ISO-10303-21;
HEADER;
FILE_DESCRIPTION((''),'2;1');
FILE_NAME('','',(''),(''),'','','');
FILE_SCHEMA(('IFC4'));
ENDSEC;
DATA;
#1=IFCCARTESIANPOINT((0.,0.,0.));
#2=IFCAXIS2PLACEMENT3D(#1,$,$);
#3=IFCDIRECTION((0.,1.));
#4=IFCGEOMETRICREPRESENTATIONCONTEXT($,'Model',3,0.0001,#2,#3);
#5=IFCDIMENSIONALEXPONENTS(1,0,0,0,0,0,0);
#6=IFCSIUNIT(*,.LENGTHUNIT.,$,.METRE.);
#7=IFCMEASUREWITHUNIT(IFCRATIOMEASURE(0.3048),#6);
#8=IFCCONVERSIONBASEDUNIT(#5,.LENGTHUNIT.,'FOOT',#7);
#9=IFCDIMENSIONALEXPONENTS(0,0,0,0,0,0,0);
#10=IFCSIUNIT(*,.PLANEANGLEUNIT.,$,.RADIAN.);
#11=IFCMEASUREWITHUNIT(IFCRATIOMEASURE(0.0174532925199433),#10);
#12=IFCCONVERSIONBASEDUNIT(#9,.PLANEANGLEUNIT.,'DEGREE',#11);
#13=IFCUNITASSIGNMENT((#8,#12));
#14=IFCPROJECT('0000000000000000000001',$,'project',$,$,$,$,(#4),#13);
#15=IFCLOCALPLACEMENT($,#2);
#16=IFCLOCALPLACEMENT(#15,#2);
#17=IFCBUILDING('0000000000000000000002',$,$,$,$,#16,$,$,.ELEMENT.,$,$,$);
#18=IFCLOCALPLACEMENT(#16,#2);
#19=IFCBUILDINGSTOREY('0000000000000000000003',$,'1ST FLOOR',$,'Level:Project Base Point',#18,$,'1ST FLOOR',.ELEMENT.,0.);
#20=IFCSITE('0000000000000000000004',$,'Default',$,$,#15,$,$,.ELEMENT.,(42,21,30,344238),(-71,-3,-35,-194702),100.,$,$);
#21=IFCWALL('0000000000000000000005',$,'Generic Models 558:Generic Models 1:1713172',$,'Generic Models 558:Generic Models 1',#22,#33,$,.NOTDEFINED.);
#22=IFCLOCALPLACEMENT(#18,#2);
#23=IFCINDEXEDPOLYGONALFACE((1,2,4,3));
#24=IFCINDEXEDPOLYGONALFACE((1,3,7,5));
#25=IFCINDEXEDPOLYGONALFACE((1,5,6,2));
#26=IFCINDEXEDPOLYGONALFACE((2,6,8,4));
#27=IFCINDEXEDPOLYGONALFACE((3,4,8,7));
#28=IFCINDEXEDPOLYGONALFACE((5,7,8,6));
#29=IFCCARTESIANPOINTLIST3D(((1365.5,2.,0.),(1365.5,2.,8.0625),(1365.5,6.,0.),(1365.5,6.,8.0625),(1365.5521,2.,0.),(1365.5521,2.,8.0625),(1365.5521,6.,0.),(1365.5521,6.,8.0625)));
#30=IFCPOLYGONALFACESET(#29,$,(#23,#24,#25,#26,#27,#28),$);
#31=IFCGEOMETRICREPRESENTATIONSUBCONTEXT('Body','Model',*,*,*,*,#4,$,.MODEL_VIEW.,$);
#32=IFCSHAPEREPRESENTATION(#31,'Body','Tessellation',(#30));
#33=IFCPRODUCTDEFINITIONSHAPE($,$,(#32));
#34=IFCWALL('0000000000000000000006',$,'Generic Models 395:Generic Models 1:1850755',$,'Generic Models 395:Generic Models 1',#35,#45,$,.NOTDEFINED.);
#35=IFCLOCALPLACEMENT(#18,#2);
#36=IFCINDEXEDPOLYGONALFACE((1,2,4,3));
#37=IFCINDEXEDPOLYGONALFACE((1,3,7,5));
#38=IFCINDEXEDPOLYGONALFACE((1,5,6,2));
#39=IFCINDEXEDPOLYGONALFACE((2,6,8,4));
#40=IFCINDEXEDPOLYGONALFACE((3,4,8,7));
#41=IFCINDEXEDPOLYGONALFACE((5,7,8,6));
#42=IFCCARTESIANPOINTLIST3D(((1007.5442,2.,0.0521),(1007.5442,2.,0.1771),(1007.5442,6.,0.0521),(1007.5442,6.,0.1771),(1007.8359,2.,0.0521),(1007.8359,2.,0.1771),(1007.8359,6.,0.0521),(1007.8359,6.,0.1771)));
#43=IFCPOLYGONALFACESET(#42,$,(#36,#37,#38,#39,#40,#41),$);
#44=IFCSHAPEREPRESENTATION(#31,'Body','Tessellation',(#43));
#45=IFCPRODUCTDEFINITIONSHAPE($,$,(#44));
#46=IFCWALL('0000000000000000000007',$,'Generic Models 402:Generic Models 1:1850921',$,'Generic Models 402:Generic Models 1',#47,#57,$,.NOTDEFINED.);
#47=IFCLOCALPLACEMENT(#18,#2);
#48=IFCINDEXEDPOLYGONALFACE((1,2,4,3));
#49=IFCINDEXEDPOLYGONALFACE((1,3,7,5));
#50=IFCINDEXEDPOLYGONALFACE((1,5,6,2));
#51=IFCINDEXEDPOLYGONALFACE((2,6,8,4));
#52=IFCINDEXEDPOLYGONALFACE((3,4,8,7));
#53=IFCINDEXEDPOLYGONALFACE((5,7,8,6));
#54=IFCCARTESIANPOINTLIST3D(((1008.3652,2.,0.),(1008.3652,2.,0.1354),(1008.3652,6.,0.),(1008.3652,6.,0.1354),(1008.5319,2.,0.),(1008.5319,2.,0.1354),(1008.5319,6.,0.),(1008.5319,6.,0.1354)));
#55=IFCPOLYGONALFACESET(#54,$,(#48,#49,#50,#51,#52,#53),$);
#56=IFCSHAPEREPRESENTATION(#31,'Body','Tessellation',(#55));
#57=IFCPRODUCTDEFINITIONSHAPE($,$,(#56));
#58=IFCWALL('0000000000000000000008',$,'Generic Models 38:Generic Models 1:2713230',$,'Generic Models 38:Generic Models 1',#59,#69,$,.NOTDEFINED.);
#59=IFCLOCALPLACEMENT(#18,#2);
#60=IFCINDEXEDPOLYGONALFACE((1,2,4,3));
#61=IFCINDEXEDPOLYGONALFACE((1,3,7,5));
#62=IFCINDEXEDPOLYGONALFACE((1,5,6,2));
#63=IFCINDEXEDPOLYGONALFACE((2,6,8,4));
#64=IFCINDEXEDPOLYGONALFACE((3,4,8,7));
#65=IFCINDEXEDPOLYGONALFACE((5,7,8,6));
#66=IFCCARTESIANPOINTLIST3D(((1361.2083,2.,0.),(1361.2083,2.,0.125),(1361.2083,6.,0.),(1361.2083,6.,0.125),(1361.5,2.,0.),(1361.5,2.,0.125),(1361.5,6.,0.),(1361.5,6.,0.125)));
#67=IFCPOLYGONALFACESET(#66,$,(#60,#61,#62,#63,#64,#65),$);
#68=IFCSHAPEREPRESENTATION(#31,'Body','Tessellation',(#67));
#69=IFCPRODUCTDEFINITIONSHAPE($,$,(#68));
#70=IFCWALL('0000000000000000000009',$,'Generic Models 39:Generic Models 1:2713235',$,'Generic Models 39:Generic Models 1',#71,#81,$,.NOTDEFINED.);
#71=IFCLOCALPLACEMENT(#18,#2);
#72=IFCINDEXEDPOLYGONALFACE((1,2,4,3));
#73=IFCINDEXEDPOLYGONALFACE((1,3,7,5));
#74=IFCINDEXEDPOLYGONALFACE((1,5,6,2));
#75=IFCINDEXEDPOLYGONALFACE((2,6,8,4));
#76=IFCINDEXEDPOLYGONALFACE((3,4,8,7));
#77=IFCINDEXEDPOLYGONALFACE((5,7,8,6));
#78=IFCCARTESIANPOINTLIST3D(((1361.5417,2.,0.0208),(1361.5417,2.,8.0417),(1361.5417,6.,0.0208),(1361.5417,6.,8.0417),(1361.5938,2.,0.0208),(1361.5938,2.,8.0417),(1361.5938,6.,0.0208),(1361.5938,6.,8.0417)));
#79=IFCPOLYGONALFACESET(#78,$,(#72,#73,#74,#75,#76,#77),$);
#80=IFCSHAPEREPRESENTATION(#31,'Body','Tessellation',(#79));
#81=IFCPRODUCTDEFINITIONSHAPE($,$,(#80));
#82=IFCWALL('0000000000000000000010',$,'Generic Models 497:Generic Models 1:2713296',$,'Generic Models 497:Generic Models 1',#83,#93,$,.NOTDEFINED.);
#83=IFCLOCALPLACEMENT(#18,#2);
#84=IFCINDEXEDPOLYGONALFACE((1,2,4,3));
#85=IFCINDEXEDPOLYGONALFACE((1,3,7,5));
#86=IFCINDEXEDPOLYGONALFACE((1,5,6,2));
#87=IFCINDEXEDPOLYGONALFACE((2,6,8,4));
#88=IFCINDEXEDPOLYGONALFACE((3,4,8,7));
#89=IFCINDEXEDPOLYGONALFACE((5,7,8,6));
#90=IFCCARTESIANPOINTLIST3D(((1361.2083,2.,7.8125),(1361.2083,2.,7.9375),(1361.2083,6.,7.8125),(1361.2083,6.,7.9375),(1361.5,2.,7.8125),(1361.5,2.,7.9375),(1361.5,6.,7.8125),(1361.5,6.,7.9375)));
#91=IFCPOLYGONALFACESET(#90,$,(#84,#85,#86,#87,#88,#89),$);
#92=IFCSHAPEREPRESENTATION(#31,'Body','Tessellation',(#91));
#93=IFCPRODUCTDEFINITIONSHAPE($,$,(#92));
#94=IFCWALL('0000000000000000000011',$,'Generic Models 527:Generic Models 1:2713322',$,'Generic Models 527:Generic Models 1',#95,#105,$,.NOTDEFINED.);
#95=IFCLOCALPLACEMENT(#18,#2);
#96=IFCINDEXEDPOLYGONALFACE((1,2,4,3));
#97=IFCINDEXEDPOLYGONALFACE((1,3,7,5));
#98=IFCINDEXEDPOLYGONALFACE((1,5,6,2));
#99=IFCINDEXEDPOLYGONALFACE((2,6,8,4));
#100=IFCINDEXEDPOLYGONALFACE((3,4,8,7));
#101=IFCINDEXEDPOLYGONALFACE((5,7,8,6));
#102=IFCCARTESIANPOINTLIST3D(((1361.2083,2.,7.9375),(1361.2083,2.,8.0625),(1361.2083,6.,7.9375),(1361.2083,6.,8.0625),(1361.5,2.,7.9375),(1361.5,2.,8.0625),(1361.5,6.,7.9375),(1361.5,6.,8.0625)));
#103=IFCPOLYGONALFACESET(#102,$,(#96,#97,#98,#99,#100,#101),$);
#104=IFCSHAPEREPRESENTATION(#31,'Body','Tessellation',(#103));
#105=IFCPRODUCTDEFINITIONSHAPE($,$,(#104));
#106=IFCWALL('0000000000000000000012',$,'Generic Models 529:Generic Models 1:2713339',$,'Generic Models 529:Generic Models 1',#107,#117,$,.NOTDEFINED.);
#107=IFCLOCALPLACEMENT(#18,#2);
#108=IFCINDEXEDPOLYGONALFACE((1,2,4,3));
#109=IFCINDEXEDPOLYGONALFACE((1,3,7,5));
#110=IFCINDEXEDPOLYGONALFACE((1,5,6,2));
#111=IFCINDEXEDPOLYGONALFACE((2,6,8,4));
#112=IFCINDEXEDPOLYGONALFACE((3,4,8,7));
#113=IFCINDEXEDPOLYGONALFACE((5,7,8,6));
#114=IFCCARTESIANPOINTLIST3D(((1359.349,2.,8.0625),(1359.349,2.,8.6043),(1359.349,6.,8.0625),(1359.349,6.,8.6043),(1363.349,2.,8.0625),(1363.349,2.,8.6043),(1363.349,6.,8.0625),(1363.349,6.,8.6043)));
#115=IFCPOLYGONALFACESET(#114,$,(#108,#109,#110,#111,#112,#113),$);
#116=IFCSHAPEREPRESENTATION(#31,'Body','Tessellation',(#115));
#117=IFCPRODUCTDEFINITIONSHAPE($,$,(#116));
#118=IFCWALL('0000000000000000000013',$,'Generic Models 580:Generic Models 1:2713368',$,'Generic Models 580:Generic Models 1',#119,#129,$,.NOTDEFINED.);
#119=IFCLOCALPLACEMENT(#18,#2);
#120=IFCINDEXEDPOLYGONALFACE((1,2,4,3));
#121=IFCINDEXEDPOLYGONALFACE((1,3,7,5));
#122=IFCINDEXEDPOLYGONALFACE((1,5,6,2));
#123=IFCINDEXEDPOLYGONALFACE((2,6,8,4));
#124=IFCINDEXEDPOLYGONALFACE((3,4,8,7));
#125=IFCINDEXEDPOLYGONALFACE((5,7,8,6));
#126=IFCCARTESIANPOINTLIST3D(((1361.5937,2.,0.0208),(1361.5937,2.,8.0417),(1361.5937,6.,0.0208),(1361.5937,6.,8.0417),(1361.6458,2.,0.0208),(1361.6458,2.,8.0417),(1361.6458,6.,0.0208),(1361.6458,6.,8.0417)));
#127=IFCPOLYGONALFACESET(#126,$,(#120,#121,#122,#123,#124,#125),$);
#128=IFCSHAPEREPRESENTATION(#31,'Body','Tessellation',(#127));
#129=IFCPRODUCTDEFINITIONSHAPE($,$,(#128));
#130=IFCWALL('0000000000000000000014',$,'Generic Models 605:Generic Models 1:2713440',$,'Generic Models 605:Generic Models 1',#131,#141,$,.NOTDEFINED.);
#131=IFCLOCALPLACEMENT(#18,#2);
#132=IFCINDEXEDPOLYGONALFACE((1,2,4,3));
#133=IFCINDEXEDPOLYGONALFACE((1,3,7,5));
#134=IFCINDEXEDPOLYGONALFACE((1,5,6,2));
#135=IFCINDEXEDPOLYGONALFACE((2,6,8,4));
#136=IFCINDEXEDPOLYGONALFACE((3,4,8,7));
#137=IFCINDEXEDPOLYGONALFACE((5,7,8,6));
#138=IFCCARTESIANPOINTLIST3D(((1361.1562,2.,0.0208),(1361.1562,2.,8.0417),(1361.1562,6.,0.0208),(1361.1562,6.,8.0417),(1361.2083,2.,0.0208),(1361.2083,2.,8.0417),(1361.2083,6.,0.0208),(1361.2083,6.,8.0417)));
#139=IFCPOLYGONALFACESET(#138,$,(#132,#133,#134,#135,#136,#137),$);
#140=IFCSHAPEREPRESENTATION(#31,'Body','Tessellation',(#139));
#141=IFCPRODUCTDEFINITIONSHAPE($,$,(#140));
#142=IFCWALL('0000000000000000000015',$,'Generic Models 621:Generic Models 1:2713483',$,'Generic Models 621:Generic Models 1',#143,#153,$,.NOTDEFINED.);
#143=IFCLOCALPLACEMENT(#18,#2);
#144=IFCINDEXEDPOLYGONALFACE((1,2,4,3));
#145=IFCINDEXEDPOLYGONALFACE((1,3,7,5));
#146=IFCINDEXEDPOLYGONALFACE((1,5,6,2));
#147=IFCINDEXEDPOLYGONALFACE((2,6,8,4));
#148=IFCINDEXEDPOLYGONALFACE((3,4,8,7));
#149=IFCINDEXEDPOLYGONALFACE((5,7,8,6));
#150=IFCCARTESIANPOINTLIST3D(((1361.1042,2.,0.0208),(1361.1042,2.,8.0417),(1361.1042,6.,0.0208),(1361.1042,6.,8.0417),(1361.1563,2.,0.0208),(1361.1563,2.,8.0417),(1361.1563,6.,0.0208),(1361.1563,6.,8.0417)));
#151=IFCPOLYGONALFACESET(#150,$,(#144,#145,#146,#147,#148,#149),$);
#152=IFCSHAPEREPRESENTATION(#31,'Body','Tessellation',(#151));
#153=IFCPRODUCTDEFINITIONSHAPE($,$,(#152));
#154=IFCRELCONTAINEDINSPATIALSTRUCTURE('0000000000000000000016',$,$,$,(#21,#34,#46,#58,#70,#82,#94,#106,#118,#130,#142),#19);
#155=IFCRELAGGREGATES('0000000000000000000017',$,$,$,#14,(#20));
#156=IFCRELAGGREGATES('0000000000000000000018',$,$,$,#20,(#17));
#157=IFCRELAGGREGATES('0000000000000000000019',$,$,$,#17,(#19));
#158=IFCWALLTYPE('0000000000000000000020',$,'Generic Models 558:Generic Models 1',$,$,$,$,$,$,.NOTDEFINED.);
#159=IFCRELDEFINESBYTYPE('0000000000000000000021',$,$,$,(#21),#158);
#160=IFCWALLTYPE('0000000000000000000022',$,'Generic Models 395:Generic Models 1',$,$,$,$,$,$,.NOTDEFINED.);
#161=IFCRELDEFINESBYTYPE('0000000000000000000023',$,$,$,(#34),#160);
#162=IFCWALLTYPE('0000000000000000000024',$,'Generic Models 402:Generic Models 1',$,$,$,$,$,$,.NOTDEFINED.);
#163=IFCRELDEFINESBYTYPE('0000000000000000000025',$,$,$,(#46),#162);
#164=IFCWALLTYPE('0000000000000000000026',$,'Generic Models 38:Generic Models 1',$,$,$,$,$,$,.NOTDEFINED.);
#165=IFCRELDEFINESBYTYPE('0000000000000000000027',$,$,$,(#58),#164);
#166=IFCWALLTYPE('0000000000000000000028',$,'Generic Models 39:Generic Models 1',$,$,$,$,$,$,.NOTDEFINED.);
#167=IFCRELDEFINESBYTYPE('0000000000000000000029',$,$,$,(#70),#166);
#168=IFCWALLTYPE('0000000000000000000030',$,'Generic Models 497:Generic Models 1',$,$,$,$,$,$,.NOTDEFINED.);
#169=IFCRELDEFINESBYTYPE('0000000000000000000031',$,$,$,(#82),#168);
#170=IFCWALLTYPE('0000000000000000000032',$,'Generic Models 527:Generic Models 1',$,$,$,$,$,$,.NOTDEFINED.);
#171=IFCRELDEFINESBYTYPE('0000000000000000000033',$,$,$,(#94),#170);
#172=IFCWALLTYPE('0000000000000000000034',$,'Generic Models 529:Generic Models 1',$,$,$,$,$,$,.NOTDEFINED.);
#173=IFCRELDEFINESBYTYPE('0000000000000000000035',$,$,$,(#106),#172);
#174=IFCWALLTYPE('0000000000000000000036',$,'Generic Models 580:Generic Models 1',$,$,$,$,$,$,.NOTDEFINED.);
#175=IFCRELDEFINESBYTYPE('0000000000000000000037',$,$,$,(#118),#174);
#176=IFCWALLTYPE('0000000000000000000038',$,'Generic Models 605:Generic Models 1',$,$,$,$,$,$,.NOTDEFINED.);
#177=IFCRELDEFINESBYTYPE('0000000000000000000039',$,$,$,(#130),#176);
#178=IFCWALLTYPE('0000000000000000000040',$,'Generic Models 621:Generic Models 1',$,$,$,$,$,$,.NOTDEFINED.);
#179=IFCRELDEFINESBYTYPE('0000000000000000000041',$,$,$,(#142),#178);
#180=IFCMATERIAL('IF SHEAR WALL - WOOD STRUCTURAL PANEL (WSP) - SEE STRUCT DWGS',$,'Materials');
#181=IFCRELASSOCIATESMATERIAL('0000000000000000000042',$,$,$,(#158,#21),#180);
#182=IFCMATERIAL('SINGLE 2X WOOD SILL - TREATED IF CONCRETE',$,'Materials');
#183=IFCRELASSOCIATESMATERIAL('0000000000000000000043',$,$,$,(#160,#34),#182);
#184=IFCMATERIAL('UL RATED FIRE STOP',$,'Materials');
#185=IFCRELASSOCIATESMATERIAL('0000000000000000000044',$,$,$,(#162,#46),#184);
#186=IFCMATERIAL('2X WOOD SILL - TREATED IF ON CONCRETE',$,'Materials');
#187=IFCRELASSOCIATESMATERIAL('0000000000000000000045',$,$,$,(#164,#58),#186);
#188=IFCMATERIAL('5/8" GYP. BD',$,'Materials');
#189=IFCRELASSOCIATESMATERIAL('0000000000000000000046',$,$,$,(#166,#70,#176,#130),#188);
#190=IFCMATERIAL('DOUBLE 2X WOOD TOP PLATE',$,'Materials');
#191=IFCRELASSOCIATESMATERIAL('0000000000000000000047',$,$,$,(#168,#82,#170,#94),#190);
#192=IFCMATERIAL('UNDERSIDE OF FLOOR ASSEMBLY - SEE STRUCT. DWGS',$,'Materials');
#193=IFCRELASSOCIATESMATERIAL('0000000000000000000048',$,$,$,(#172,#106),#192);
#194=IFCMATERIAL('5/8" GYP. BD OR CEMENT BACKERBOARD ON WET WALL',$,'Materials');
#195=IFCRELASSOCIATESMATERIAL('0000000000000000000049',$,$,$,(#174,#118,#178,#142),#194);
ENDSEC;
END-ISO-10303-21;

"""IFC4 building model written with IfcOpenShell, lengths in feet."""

from ifc_helpers import new_model, entity, si_unit, converted_unit, direction, frame, frame_2d, origin, origin_2d_with_axis, place, context, subcontext, project, spatial, rectangle, extrude, material, type_object, element, save


model = new_model("IFC4")

# Units and contexts
model_context = context("Model", 3, precision=0.0001, world=origin(), true_north=direction((0.0, 1.0)))
body_context = subcontext(model_context, "Body", "Model", "MODEL_VIEW")
ifc_project = project(units=[converted_unit("LENGTHUNIT", "FOOT", entity("IfcRatioMeasure", 0.3048), si_unit("LENGTHUNIT", "METRE"), dimensions=[1, 0, 0, 0, 0, 0, 0]), converted_unit("PLANEANGLEUNIT", "DEGREE", entity("IfcRatioMeasure", 0.0174532925199433), si_unit("PLANEANGLEUNIT", "RADIAN"), dimensions=[0, 0, 0, 0, 0, 0, 0])], contexts=[model_context])

# Site, building, storey
site_placement = place(None, origin())
site = spatial("IfcSite", under=ifc_project, at=site_placement, Name="Default", CompositionType="ELEMENT", RefLatitude=(42, 21, 30, 344238), RefLongitude=(-71, -3, -35, -194702), RefElevation=100.0)
building_placement = place(site_placement, origin())
building = spatial("IfcBuilding", under=site, at=building_placement, CompositionType="ELEMENT")
storey_placement = place(building_placement, origin())
storey = spatial("IfcBuildingStorey", under=building, at=storey_placement, Name="1ST FLOOR", ObjectType="Level:Project Base Point", LongName="1ST FLOOR", CompositionType="ELEMENT", Elevation=0.0)

# Walls
ifc_material_1 = material(Name="2X WOOD SILL - TREATED IF ON CONCRETE", Category="Materials")
ifc_material_2 = material(Name="DOUBLE 2X WOOD TOP PLATE", Category="Materials")
ifc_material_3 = material(Name="UNDERSIDE OF FLOOR ASSEMBLY - SEE STRUCT. DWGS", Category="Materials")
ifc_material_4 = material(Name="5/8\" GYP. BD", Category="Materials")
ifc_material_5 = material(Name="5/8\" GYP. BD OR CEMENT BACKERBOARD ON WET WALL", Category="Materials")
ifc_material_6 = material(Name="IF SHEAR WALL - WOOD STRUCTURAL PANEL (WSP) - SEE STRUCT DWGS", Category="Materials")
wall_type_1 = type_object("IfcWallType", Name="Generic Models 558:Generic Models 1", PredefinedType="NOTDEFINED", material=ifc_material_6)
wall_1_placement = place(storey_placement, frame((1365.5, 2.0, 0.0), z_axis=(0.0, 0.0, 1.0), x_axis=(0.0, 1.0, 0.0)))
element("IfcWall", 1, at=wall_1_placement, inside=storey, type_object=wall_type_1, material=ifc_material_6, Name="Generic Models 558:Generic Models 1:1713172", ObjectType="Generic Models 558:Generic Models 1", PredefinedType="NOTDEFINED", context=body_context, shape_type="SweptSolid", body=[
    extrude(rectangle(XDim=4.0, YDim=0.0521, at=frame_2d((0.0, 0.0), x_axis=(1.0, 0.0))), frame((2.0, -0.026, 0.0)), (0.0, 0.0, 1.0), 8.0625),
])
ifc_material_7 = material(Name="SINGLE 2X WOOD SILL - TREATED IF CONCRETE", Category="Materials")
wall_type_2 = type_object("IfcWallType", Name="Generic Models 395:Generic Models 1", PredefinedType="NOTDEFINED", material=ifc_material_7)
wall_2_placement = place(storey_placement, frame((1007.5442, 2.0, 0.0521), z_axis=(0.0, 0.0, 1.0), x_axis=(0.0, 1.0, 0.0)))
element("IfcWall", 2, at=wall_2_placement, inside=storey, type_object=wall_type_2, material=ifc_material_7, Name="Generic Models 395:Generic Models 1:1850755", ObjectType="Generic Models 395:Generic Models 1", PredefinedType="NOTDEFINED", context=body_context, shape_type="SweptSolid", body=[
    extrude(rectangle(XDim=4.0, YDim=0.2917, at=frame_2d((0.0, 0.0), x_axis=(1.0, 0.0))), frame((2.0, -0.1458, 0.0)), (0.0, 0.0, 1.0), 0.125),
])
ifc_material_8 = material(Name="UL RATED FIRE STOP", Category="Materials")
wall_type_3 = type_object("IfcWallType", Name="Generic Models 402:Generic Models 1", PredefinedType="NOTDEFINED", material=ifc_material_8)
wall_3_placement = place(storey_placement, frame((1008.3652, 2.0, 0.0), z_axis=(0.0, 0.0, 1.0), x_axis=(0.0, 1.0, 0.0)))
element("IfcWall", 3, at=wall_3_placement, inside=storey, type_object=wall_type_3, material=ifc_material_8, Name="Generic Models 402:Generic Models 1:1850921", ObjectType="Generic Models 402:Generic Models 1", PredefinedType="NOTDEFINED", context=body_context, shape_type="SweptSolid", body=[
    extrude(rectangle(XDim=4.0, YDim=0.1667, at=frame_2d((0.0, 0.0), x_axis=(1.0, 0.0))), frame((2.0, -0.0833, 0.0)), (0.0, 0.0, 1.0), 0.1354),
])
wall_type_4 = type_object("IfcWallType", Name="Generic Models 38:Generic Models 1", PredefinedType="NOTDEFINED", material=ifc_material_1)
wall_4_placement = place(storey_placement, frame((1361.2083, 2.0, 0.0), z_axis=(0.0, 0.0, 1.0), x_axis=(0.0, 1.0, 0.0)))
element("IfcWall", 4, at=wall_4_placement, inside=storey, type_object=wall_type_4, material=ifc_material_1, Name="Generic Models 38:Generic Models 1:2713230", ObjectType="Generic Models 38:Generic Models 1", PredefinedType="NOTDEFINED", context=body_context, shape_type="SweptSolid", body=[
    extrude(rectangle(XDim=4.0, YDim=0.2917, at=frame_2d((0.0, 0.0), x_axis=(1.0, 0.0))), frame((2.0, -0.1458, 0.0)), (0.0, 0.0, 1.0), 0.125),
])
wall_type_5 = type_object("IfcWallType", Name="Generic Models 39:Generic Models 1", PredefinedType="NOTDEFINED", material=ifc_material_4)
wall_5_placement = place(storey_placement, frame((1361.5417, 2.0, 0.0208), z_axis=(0.0, 0.0, 1.0), x_axis=(0.0, 1.0, 0.0)))
element("IfcWall", 5, at=wall_5_placement, inside=storey, type_object=wall_type_5, material=ifc_material_4, Name="Generic Models 39:Generic Models 1:2713235", ObjectType="Generic Models 39:Generic Models 1", PredefinedType="NOTDEFINED", context=body_context, shape_type="SweptSolid", body=[
    extrude(rectangle(XDim=4.0, YDim=0.0521, at=frame_2d((0.0, 0.0), x_axis=(1.0, 0.0))), frame((2.0, -0.026, 0.0)), (0.0, 0.0, 1.0), 8.0208),
])
wall_type_6 = type_object("IfcWallType", Name="Generic Models 497:Generic Models 1", PredefinedType="NOTDEFINED", material=ifc_material_2)
wall_6_placement = place(storey_placement, frame((1361.2083, 2.0, 7.8125), z_axis=(0.0, 0.0, 1.0), x_axis=(0.0, 1.0, 0.0)))
element("IfcWall", 6, at=wall_6_placement, inside=storey, type_object=wall_type_6, material=ifc_material_2, Name="Generic Models 497:Generic Models 1:2713296", ObjectType="Generic Models 497:Generic Models 1", PredefinedType="NOTDEFINED", context=body_context, shape_type="SweptSolid", body=[
    extrude(rectangle(XDim=4.0, YDim=0.2917, at=frame_2d((0.0, 0.0), x_axis=(1.0, 0.0))), frame((2.0, -0.1458, 0.0)), (0.0, 0.0, 1.0), 0.125),
])
wall_type_7 = type_object("IfcWallType", Name="Generic Models 527:Generic Models 1", PredefinedType="NOTDEFINED", material=ifc_material_2)
wall_7_placement = place(storey_placement, frame((1361.2083, 2.0, 7.9375), z_axis=(0.0, 0.0, 1.0), x_axis=(0.0, 1.0, 0.0)))
element("IfcWall", 7, at=wall_7_placement, inside=storey, type_object=wall_type_7, material=ifc_material_2, Name="Generic Models 527:Generic Models 1:2713322", ObjectType="Generic Models 527:Generic Models 1", PredefinedType="NOTDEFINED", context=body_context, shape_type="SweptSolid", body=[
    extrude(rectangle(XDim=4.0, YDim=0.2917, at=frame_2d((0.0, 0.0), x_axis=(1.0, 0.0))), frame((2.0, -0.1458, 0.0)), (0.0, 0.0, 1.0), 0.125),
])
wall_type_8 = type_object("IfcWallType", Name="Generic Models 529:Generic Models 1", PredefinedType="NOTDEFINED", material=ifc_material_3)
wall_8_placement = place(storey_placement, frame((1359.349, 2.0, 8.0625), z_axis=(0.0, 0.0, 1.0), x_axis=(0.0, 1.0, 0.0)))
element("IfcWall", 8, at=wall_8_placement, inside=storey, type_object=wall_type_8, material=ifc_material_3, Name="Generic Models 529:Generic Models 1:2713339", ObjectType="Generic Models 529:Generic Models 1", PredefinedType="NOTDEFINED", context=body_context, shape_type="SweptSolid", body=[
    extrude(rectangle(XDim=4.0, YDim=4.0, at=origin_2d_with_axis()), frame((2.0, -2.0, 0.0)), (0.0, 0.0, 1.0), 0.5418),
])
wall_type_9 = type_object("IfcWallType", Name="Generic Models 580:Generic Models 1", PredefinedType="NOTDEFINED", material=ifc_material_5)
wall_9_placement = place(storey_placement, frame((1361.5938, 2.0, 0.0208), z_axis=(0.0, 0.0, 1.0), x_axis=(0.0, 1.0, 0.0)))
element("IfcWall", 9, at=wall_9_placement, inside=storey, type_object=wall_type_9, material=ifc_material_5, Name="Generic Models 580:Generic Models 1:2713368", ObjectType="Generic Models 580:Generic Models 1", PredefinedType="NOTDEFINED", context=body_context, shape_type="SweptSolid", body=[
    extrude(rectangle(XDim=4.0, YDim=0.0521, at=frame_2d((0.0, 0.0), x_axis=(1.0, 0.0))), frame((2.0, -0.026, 0.0)), (0.0, 0.0, 1.0), 8.0208),
])
wall_type_10 = type_object("IfcWallType", Name="Generic Models 605:Generic Models 1", PredefinedType="NOTDEFINED", material=ifc_material_4)
wall_10_placement = place(storey_placement, frame((1361.1562, 2.0, 0.0208), z_axis=(0.0, 0.0, 1.0), x_axis=(0.0, 1.0, 0.0)))
element("IfcWall", 10, at=wall_10_placement, inside=storey, type_object=wall_type_10, material=ifc_material_4, Name="Generic Models 605:Generic Models 1:2713440", ObjectType="Generic Models 605:Generic Models 1", PredefinedType="NOTDEFINED", context=body_context, shape_type="SweptSolid", body=[
    extrude(rectangle(XDim=4.0, YDim=0.0521, at=frame_2d((0.0, 0.0), x_axis=(1.0, 0.0))), frame((2.0, -0.026, 0.0)), (0.0, 0.0, 1.0), 8.0208),
])
wall_type_11 = type_object("IfcWallType", Name="Generic Models 621:Generic Models 1", PredefinedType="NOTDEFINED", material=ifc_material_5)
wall_11_placement = place(storey_placement, frame((1361.1042, 2.0, 0.0208), z_axis=(0.0, 0.0, 1.0), x_axis=(0.0, 1.0, 0.0)))
element("IfcWall", 11, at=wall_11_placement, inside=storey, type_object=wall_type_11, material=ifc_material_5, Name="Generic Models 621:Generic Models 1:2713483", ObjectType="Generic Models 621:Generic Models 1", PredefinedType="NOTDEFINED", context=body_context, shape_type="SweptSolid", body=[
    extrude(rectangle(XDim=4.0, YDim=0.0521, at=frame_2d((0.0, 0.0), x_axis=(1.0, 0.0))), frame((2.0, -0.026, 0.0)), (0.0, 0.0, 1.0), 8.0208),
])

save(model, "model.ifc")
